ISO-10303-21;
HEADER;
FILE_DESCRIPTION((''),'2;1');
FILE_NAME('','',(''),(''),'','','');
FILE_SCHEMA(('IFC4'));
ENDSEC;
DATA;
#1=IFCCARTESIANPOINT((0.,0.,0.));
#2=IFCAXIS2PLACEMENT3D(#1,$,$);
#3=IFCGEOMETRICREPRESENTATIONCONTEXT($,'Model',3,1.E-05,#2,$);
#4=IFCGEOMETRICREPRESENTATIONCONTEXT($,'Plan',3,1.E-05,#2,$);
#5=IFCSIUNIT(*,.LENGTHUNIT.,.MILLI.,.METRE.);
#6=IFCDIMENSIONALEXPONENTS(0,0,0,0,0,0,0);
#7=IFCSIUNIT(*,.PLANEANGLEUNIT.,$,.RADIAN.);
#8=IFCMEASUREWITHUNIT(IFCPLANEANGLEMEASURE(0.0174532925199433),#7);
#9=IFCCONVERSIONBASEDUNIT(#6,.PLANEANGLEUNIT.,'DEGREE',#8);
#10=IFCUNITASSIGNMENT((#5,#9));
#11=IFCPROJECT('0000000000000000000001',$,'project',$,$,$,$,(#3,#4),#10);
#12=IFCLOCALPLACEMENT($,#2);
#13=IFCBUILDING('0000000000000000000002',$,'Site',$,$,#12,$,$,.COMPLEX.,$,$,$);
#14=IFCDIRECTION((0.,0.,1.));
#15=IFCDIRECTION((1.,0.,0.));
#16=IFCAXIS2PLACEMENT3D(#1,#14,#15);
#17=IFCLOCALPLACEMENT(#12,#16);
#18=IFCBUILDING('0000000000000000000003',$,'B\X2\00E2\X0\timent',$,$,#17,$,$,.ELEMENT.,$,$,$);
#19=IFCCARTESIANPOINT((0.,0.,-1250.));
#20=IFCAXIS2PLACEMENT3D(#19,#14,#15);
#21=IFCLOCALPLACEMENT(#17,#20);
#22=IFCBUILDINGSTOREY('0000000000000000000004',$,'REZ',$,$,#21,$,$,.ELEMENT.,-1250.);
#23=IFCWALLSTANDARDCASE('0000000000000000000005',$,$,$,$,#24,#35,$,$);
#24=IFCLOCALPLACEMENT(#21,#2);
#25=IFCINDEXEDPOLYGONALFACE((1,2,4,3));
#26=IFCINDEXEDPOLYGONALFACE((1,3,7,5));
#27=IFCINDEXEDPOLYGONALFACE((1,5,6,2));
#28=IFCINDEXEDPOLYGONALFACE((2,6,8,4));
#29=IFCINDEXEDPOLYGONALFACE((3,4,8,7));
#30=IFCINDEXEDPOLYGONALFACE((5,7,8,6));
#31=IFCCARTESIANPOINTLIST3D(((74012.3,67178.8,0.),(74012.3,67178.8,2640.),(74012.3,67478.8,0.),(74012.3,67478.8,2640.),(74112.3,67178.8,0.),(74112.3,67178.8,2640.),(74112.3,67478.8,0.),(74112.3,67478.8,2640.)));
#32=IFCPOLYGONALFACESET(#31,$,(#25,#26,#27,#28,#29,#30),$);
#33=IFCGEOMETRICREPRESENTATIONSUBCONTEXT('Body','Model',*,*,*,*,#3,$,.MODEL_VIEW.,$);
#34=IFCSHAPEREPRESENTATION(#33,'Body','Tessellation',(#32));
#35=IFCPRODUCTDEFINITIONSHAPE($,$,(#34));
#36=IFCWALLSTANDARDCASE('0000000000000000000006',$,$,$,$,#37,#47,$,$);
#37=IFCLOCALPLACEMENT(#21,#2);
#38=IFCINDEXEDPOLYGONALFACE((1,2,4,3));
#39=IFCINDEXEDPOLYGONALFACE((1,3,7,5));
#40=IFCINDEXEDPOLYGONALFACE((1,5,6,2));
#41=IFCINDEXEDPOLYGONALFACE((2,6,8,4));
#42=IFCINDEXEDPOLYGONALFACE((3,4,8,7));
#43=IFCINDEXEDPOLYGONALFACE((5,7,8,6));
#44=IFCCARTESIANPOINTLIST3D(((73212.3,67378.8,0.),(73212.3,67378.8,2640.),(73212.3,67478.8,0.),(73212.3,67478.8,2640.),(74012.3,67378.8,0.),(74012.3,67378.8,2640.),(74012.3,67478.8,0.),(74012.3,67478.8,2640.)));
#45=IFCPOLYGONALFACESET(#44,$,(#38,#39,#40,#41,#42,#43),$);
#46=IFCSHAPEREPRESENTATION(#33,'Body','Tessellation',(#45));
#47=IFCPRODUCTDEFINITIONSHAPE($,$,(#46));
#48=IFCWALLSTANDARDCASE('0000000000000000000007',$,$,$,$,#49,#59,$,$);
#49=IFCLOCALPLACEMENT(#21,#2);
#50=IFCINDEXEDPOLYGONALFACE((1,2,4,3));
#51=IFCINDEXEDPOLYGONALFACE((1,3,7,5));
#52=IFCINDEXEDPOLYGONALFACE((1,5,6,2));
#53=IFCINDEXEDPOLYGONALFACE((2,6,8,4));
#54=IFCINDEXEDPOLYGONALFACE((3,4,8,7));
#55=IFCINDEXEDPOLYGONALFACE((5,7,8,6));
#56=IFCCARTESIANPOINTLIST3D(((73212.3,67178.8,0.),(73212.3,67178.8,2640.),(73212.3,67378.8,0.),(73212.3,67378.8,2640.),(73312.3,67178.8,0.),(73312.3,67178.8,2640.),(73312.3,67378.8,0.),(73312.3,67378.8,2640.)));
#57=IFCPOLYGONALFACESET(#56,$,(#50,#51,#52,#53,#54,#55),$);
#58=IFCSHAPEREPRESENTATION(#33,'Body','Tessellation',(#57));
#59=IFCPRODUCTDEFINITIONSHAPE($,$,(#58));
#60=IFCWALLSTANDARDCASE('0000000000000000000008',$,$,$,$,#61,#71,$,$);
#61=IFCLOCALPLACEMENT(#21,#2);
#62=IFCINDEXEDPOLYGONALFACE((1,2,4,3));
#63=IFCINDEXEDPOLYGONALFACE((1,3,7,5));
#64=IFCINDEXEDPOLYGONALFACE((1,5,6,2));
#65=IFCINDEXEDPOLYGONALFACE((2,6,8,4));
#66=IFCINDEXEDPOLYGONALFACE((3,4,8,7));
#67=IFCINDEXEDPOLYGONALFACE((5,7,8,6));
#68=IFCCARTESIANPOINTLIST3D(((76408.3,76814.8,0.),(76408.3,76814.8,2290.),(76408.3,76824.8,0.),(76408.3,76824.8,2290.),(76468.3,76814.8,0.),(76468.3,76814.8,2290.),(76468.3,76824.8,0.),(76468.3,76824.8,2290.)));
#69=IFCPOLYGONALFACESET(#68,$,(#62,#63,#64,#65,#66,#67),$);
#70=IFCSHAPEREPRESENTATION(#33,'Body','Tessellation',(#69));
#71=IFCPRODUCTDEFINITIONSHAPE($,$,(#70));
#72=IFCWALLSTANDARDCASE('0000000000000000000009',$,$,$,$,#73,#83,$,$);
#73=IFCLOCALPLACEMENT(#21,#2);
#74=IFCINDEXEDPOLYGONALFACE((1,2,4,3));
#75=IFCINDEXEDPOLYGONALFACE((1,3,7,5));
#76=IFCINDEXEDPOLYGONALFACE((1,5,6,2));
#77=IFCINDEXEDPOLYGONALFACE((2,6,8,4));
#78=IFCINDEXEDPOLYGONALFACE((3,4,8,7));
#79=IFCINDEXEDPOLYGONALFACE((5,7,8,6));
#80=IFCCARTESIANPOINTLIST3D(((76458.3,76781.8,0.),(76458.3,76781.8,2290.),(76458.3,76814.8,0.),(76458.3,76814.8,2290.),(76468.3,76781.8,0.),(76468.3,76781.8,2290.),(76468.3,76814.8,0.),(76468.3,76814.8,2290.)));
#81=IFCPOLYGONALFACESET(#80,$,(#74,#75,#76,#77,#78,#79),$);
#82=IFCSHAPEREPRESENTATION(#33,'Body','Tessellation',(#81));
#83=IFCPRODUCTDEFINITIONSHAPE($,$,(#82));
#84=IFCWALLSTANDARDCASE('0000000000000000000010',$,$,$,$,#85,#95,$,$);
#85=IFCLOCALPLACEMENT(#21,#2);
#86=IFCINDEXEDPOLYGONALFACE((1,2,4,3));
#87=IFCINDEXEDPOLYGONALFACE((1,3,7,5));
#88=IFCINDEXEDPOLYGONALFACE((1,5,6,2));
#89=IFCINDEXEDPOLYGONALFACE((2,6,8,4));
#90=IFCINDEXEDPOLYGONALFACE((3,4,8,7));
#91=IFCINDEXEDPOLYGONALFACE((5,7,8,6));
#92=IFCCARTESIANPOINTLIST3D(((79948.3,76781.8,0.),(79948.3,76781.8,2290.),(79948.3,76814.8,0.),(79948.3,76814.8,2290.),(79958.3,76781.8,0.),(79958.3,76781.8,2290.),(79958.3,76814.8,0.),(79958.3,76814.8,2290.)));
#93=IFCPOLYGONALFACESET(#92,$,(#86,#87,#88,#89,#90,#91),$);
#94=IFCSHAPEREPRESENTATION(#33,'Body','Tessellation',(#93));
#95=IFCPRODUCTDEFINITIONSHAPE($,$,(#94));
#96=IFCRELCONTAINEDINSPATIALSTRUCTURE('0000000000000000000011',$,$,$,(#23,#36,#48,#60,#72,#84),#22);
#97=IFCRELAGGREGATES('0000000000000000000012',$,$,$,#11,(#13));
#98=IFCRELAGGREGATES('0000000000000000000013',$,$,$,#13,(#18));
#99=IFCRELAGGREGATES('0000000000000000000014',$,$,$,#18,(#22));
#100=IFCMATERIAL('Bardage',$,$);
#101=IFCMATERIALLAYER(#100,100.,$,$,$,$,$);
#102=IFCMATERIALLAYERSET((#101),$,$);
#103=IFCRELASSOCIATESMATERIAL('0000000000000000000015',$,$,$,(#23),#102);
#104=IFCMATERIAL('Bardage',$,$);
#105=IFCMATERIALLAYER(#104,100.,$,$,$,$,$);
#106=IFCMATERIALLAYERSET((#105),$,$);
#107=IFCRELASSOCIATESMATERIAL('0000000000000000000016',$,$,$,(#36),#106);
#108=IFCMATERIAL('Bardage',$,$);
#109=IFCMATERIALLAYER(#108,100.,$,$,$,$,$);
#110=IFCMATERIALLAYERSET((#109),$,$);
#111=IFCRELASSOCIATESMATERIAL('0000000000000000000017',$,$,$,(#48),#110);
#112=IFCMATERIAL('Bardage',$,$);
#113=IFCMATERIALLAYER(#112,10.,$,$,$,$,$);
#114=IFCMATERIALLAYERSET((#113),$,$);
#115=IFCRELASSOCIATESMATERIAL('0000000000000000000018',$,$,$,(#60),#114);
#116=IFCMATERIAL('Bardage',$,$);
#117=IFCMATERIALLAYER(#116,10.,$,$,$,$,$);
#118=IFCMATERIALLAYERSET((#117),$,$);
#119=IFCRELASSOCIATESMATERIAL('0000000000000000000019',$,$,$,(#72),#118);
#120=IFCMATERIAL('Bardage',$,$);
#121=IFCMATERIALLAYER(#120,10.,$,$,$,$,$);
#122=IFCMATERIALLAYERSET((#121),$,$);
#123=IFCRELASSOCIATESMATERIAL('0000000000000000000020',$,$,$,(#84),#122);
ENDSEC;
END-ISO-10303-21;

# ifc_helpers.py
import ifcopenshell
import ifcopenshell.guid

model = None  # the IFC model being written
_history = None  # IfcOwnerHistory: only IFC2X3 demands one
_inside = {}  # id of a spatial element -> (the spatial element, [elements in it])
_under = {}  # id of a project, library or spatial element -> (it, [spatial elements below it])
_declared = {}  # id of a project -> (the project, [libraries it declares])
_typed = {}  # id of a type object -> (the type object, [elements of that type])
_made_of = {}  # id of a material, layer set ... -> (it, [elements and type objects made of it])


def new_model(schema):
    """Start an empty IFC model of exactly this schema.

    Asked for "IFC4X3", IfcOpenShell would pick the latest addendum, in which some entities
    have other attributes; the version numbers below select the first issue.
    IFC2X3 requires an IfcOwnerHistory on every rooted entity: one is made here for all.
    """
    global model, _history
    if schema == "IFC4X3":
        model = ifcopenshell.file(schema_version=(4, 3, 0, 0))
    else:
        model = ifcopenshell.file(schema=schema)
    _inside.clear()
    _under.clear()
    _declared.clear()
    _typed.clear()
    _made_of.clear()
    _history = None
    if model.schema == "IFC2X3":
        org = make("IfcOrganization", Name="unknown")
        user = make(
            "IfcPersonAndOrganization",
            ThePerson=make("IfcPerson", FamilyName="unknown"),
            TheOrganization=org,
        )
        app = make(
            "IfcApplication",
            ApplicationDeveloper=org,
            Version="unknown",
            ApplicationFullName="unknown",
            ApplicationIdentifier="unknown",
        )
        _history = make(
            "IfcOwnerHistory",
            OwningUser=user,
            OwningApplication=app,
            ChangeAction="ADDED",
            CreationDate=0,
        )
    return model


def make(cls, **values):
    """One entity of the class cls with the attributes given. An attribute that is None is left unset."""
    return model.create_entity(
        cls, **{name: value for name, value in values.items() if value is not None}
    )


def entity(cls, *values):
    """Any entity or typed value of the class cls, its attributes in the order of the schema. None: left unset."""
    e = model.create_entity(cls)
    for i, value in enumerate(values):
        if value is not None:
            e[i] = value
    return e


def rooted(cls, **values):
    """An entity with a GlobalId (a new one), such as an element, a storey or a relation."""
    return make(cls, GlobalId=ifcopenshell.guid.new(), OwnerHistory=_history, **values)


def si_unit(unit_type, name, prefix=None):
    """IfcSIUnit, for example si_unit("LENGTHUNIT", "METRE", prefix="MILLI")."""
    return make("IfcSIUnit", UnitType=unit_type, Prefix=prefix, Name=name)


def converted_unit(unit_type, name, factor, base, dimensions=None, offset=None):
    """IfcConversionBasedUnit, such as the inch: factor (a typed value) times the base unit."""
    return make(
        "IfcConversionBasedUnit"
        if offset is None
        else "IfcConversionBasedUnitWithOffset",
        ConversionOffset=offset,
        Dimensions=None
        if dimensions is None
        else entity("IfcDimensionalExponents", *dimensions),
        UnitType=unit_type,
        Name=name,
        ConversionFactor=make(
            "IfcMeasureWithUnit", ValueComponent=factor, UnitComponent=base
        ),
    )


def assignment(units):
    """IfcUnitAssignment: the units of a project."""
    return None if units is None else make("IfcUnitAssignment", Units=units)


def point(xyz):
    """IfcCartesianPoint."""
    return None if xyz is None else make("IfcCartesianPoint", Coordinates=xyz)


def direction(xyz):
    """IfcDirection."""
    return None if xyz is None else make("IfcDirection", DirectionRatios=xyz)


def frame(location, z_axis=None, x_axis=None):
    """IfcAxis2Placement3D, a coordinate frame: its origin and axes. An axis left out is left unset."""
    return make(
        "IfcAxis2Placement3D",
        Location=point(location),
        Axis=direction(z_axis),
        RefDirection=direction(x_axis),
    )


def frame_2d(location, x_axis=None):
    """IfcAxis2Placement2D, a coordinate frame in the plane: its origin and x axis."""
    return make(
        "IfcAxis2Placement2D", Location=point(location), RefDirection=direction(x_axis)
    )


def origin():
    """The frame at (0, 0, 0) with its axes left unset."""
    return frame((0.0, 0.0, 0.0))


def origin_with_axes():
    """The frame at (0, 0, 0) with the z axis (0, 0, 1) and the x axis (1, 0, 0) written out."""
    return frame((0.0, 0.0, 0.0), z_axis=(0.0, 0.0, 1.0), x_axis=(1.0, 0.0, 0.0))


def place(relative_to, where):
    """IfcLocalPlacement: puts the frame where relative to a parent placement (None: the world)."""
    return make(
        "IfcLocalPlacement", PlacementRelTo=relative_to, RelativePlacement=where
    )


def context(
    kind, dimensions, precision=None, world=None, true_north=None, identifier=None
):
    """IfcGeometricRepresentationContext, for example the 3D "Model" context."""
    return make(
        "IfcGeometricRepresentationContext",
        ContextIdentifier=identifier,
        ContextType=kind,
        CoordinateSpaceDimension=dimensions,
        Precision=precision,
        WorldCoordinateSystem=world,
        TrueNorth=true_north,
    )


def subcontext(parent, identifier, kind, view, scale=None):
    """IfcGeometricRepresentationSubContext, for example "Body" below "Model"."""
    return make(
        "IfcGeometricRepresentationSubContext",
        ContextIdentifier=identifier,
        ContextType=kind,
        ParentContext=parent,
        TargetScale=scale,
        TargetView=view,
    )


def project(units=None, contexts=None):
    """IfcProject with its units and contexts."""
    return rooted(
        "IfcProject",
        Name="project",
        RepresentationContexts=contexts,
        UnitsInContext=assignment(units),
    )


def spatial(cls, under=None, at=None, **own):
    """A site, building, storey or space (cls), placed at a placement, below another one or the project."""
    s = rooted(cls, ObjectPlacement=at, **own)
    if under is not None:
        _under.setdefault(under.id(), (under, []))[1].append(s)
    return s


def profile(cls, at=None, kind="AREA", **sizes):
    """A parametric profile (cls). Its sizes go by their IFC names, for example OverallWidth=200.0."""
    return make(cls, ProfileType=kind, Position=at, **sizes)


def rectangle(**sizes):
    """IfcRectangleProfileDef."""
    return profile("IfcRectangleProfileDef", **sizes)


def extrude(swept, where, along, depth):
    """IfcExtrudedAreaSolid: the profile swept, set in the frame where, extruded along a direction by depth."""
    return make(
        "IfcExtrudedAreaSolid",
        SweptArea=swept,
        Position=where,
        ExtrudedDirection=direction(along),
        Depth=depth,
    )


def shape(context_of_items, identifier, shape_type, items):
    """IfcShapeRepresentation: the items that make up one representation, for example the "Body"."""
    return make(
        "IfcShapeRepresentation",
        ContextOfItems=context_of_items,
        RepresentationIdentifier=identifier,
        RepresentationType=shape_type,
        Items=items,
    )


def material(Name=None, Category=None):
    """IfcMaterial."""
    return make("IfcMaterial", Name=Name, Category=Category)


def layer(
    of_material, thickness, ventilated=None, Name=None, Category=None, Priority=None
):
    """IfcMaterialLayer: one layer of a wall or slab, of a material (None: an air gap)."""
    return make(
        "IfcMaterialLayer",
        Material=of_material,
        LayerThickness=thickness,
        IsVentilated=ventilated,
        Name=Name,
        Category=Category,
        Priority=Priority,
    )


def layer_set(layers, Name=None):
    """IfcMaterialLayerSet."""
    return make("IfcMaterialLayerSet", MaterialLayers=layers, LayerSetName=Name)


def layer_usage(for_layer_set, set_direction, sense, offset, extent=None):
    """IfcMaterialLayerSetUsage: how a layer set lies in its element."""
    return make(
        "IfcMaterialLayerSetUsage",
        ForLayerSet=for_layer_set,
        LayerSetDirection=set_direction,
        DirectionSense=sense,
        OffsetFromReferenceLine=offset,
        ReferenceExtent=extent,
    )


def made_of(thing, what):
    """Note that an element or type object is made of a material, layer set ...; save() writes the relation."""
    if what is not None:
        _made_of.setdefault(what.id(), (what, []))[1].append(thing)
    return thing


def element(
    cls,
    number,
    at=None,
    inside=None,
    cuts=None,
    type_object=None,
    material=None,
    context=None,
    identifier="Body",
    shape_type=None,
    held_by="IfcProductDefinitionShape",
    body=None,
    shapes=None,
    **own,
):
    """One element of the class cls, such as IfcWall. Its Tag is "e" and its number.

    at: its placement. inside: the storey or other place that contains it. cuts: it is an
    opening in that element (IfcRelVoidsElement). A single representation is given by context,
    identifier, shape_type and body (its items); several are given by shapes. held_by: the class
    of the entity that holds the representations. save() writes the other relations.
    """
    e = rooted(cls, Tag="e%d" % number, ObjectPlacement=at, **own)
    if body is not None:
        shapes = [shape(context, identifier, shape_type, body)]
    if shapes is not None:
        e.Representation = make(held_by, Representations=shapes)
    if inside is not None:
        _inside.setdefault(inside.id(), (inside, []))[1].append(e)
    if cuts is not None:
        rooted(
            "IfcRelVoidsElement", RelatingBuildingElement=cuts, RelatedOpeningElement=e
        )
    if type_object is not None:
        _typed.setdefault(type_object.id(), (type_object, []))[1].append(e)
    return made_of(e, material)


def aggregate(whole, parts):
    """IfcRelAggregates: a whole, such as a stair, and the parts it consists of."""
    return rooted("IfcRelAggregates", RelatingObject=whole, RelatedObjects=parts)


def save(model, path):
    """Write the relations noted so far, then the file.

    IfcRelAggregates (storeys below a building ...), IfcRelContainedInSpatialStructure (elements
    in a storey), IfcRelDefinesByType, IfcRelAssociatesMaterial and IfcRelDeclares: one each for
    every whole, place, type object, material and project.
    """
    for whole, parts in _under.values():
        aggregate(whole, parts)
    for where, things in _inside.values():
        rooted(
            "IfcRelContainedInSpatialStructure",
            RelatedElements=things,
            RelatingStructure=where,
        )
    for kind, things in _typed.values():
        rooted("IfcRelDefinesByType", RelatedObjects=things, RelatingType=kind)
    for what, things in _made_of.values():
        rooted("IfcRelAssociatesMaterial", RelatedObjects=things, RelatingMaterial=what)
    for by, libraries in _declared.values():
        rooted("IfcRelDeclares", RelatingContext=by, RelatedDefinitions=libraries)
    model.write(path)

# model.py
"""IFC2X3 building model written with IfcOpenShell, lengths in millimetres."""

from ifc_helpers import new_model, entity, si_unit, converted_unit, frame, frame_2d, origin, origin_with_axes, place, context, subcontext, project, spatial, rectangle, extrude, material, layer, layer_set, layer_usage, element, save


model = new_model("IFC2X3")

# Units and contexts
model_context = context("Model", 3, precision=1e-05, world=origin())
plan_context = context("Plan", 3, precision=1e-05, world=origin())
body_context = subcontext(model_context, "Body", "Model", "MODEL_VIEW")
ifc_project = project(units=[si_unit("LENGTHUNIT", "METRE", prefix="MILLI"), converted_unit("PLANEANGLEUNIT", "DEGREE", entity("IfcPlaneAngleMeasure", 0.0174532925199433), si_unit("PLANEANGLEUNIT", "RADIAN"), dimensions=[0, 0, 0, 0, 0, 0, 0])], contexts=[model_context, plan_context])

# Buildings, storey
building_1_placement = place(None, origin())
building_1 = spatial("IfcBuilding", under=ifc_project, at=building_1_placement, Name="Site", CompositionType="COMPLEX")
building_2_placement = place(building_1_placement, origin_with_axes())
building_2 = spatial("IfcBuilding", under=building_1, at=building_2_placement, Name="Bâtiment", CompositionType="ELEMENT")
storey_placement = place(building_2_placement, frame((0.0, 0.0, -1250.0), z_axis=(0.0, 0.0, 1.0), x_axis=(1.0, 0.0, 0.0)))
storey = spatial("IfcBuildingStorey", under=building_2, at=storey_placement, Name="REZ", CompositionType="ELEMENT", Elevation=-1250.0)

# Walls
ifc_material_1 = material(Name="Bardage")
ifc_layer_1 = layer(ifc_material_1, 100.0)
ifc_layer_set_1 = layer_set([ifc_layer_1])
ifc_layer_usage_1 = layer_usage(ifc_layer_set_1, "AXIS2", "POSITIVE", 0.0)
wall_1_placement = place(storey_placement, frame((74112.3, 67178.8, 0.0), z_axis=(0.0, 0.0, 1.0), x_axis=(0.0, 1.0, 0.0)))
element("IfcWallStandardCase", 1, at=wall_1_placement, inside=storey, material=ifc_layer_usage_1, context=body_context, shape_type="SweptSolid", body=[
    extrude(rectangle(XDim=300.0, YDim=100.0, at=frame_2d((150.0, 50.0), x_axis=(1.0, 0.0))), origin_with_axes(), (0.0, 0.0, 1.0), 2640.0),
])
ifc_material_2 = material(Name="Bardage")
ifc_layer_2 = layer(ifc_material_2, 100.0)
ifc_layer_set_2 = layer_set([ifc_layer_2])
ifc_layer_usage_2 = layer_usage(ifc_layer_set_2, "AXIS2", "POSITIVE", 0.0)
wall_2_placement = place(storey_placement, frame((74012.3, 67478.8, 0.0), z_axis=(0.0, 0.0, 1.0), x_axis=(-1.0, 0.0, 0.0)))
element("IfcWallStandardCase", 2, at=wall_2_placement, inside=storey, material=ifc_layer_usage_2, context=body_context, shape_type="SweptSolid", body=[
    extrude(rectangle(XDim=800.0, YDim=100.0, at=frame_2d((400.0, 50.0), x_axis=(1.0, 0.0))), origin_with_axes(), (0.0, 0.0, 1.0), 2640.0),
])
ifc_material_3 = material(Name="Bardage")
ifc_layer_3 = layer(ifc_material_3, 100.0)
ifc_layer_set_3 = layer_set([ifc_layer_3])
ifc_layer_usage_3 = layer_usage(ifc_layer_set_3, "AXIS2", "POSITIVE", 0.0)
wall_3_placement = place(storey_placement, frame((73212.3, 67378.8, 0.0), z_axis=(0.0, 0.0, 1.0), x_axis=(0.0, -1.0, 0.0)))
element("IfcWallStandardCase", 3, at=wall_3_placement, inside=storey, material=ifc_layer_usage_3, context=body_context, shape_type="SweptSolid", body=[
    extrude(rectangle(XDim=200.0, YDim=100.0, at=frame_2d((100.0, 50.0), x_axis=(1.0, 0.0))), origin_with_axes(), (0.0, 0.0, 1.0), 2640.0),
])
ifc_material_4 = material(Name="Bardage")
ifc_layer_4 = layer(ifc_material_4, 10.0)
ifc_layer_set_4 = layer_set([ifc_layer_4])
ifc_layer_usage_4 = layer_usage(ifc_layer_set_4, "AXIS2", "POSITIVE", 0.0)
wall_4_placement = place(storey_placement, frame((76468.3, 76824.8, 0.0), z_axis=(0.0, 0.0, 1.0), x_axis=(-1.0, 0.0, 0.0)))
element("IfcWallStandardCase", 4, at=wall_4_placement, inside=storey, material=ifc_layer_usage_4, context=body_context, shape_type="SweptSolid", body=[
    extrude(rectangle(XDim=60.0, YDim=10.0, at=frame_2d((30.0, 5.0), x_axis=(1.0, 0.0))), origin_with_axes(), (0.0, 0.0, 1.0), 2290.0),
])
ifc_material_5 = material(Name="Bardage")
ifc_layer_5 = layer(ifc_material_5, 10.0)
ifc_layer_set_5 = layer_set([ifc_layer_5])
ifc_layer_usage_5 = layer_usage(ifc_layer_set_5, "AXIS2", "POSITIVE", 0.0)
wall_5_placement = place(storey_placement, frame((76468.3, 76781.8, 0.0), z_axis=(0.0, 0.0, 1.0), x_axis=(0.0, 1.0, 0.0)))
element("IfcWallStandardCase", 5, at=wall_5_placement, inside=storey, material=ifc_layer_usage_5, context=body_context, shape_type="SweptSolid", body=[
    extrude(rectangle(XDim=33.0, YDim=10.0, at=frame_2d((16.5, 5.0), x_axis=(1.0, 0.0))), origin_with_axes(), (0.0, 0.0, 1.0), 2290.0),
])
ifc_material_6 = material(Name="Bardage")
ifc_layer_6 = layer(ifc_material_6, 10.0)
ifc_layer_set_6 = layer_set([ifc_layer_6])
ifc_layer_usage_6 = layer_usage(ifc_layer_set_6, "AXIS2", "POSITIVE", 0.0)
wall_6_placement = place(storey_placement, frame((79948.3, 76814.8, 0.0), z_axis=(0.0, 0.0, 1.0), x_axis=(0.0, -1.0, 0.0)))
element("IfcWallStandardCase", 6, at=wall_6_placement, inside=storey, material=ifc_layer_usage_6, context=body_context, shape_type="SweptSolid", body=[
    extrude(rectangle(XDim=33.0, YDim=10.0, at=frame_2d((16.5, 5.0), x_axis=(1.0, 0.0))), origin_with_axes(), (0.0, 0.0, 1.0), 2290.0),
])

save(model, "model.ifc")
